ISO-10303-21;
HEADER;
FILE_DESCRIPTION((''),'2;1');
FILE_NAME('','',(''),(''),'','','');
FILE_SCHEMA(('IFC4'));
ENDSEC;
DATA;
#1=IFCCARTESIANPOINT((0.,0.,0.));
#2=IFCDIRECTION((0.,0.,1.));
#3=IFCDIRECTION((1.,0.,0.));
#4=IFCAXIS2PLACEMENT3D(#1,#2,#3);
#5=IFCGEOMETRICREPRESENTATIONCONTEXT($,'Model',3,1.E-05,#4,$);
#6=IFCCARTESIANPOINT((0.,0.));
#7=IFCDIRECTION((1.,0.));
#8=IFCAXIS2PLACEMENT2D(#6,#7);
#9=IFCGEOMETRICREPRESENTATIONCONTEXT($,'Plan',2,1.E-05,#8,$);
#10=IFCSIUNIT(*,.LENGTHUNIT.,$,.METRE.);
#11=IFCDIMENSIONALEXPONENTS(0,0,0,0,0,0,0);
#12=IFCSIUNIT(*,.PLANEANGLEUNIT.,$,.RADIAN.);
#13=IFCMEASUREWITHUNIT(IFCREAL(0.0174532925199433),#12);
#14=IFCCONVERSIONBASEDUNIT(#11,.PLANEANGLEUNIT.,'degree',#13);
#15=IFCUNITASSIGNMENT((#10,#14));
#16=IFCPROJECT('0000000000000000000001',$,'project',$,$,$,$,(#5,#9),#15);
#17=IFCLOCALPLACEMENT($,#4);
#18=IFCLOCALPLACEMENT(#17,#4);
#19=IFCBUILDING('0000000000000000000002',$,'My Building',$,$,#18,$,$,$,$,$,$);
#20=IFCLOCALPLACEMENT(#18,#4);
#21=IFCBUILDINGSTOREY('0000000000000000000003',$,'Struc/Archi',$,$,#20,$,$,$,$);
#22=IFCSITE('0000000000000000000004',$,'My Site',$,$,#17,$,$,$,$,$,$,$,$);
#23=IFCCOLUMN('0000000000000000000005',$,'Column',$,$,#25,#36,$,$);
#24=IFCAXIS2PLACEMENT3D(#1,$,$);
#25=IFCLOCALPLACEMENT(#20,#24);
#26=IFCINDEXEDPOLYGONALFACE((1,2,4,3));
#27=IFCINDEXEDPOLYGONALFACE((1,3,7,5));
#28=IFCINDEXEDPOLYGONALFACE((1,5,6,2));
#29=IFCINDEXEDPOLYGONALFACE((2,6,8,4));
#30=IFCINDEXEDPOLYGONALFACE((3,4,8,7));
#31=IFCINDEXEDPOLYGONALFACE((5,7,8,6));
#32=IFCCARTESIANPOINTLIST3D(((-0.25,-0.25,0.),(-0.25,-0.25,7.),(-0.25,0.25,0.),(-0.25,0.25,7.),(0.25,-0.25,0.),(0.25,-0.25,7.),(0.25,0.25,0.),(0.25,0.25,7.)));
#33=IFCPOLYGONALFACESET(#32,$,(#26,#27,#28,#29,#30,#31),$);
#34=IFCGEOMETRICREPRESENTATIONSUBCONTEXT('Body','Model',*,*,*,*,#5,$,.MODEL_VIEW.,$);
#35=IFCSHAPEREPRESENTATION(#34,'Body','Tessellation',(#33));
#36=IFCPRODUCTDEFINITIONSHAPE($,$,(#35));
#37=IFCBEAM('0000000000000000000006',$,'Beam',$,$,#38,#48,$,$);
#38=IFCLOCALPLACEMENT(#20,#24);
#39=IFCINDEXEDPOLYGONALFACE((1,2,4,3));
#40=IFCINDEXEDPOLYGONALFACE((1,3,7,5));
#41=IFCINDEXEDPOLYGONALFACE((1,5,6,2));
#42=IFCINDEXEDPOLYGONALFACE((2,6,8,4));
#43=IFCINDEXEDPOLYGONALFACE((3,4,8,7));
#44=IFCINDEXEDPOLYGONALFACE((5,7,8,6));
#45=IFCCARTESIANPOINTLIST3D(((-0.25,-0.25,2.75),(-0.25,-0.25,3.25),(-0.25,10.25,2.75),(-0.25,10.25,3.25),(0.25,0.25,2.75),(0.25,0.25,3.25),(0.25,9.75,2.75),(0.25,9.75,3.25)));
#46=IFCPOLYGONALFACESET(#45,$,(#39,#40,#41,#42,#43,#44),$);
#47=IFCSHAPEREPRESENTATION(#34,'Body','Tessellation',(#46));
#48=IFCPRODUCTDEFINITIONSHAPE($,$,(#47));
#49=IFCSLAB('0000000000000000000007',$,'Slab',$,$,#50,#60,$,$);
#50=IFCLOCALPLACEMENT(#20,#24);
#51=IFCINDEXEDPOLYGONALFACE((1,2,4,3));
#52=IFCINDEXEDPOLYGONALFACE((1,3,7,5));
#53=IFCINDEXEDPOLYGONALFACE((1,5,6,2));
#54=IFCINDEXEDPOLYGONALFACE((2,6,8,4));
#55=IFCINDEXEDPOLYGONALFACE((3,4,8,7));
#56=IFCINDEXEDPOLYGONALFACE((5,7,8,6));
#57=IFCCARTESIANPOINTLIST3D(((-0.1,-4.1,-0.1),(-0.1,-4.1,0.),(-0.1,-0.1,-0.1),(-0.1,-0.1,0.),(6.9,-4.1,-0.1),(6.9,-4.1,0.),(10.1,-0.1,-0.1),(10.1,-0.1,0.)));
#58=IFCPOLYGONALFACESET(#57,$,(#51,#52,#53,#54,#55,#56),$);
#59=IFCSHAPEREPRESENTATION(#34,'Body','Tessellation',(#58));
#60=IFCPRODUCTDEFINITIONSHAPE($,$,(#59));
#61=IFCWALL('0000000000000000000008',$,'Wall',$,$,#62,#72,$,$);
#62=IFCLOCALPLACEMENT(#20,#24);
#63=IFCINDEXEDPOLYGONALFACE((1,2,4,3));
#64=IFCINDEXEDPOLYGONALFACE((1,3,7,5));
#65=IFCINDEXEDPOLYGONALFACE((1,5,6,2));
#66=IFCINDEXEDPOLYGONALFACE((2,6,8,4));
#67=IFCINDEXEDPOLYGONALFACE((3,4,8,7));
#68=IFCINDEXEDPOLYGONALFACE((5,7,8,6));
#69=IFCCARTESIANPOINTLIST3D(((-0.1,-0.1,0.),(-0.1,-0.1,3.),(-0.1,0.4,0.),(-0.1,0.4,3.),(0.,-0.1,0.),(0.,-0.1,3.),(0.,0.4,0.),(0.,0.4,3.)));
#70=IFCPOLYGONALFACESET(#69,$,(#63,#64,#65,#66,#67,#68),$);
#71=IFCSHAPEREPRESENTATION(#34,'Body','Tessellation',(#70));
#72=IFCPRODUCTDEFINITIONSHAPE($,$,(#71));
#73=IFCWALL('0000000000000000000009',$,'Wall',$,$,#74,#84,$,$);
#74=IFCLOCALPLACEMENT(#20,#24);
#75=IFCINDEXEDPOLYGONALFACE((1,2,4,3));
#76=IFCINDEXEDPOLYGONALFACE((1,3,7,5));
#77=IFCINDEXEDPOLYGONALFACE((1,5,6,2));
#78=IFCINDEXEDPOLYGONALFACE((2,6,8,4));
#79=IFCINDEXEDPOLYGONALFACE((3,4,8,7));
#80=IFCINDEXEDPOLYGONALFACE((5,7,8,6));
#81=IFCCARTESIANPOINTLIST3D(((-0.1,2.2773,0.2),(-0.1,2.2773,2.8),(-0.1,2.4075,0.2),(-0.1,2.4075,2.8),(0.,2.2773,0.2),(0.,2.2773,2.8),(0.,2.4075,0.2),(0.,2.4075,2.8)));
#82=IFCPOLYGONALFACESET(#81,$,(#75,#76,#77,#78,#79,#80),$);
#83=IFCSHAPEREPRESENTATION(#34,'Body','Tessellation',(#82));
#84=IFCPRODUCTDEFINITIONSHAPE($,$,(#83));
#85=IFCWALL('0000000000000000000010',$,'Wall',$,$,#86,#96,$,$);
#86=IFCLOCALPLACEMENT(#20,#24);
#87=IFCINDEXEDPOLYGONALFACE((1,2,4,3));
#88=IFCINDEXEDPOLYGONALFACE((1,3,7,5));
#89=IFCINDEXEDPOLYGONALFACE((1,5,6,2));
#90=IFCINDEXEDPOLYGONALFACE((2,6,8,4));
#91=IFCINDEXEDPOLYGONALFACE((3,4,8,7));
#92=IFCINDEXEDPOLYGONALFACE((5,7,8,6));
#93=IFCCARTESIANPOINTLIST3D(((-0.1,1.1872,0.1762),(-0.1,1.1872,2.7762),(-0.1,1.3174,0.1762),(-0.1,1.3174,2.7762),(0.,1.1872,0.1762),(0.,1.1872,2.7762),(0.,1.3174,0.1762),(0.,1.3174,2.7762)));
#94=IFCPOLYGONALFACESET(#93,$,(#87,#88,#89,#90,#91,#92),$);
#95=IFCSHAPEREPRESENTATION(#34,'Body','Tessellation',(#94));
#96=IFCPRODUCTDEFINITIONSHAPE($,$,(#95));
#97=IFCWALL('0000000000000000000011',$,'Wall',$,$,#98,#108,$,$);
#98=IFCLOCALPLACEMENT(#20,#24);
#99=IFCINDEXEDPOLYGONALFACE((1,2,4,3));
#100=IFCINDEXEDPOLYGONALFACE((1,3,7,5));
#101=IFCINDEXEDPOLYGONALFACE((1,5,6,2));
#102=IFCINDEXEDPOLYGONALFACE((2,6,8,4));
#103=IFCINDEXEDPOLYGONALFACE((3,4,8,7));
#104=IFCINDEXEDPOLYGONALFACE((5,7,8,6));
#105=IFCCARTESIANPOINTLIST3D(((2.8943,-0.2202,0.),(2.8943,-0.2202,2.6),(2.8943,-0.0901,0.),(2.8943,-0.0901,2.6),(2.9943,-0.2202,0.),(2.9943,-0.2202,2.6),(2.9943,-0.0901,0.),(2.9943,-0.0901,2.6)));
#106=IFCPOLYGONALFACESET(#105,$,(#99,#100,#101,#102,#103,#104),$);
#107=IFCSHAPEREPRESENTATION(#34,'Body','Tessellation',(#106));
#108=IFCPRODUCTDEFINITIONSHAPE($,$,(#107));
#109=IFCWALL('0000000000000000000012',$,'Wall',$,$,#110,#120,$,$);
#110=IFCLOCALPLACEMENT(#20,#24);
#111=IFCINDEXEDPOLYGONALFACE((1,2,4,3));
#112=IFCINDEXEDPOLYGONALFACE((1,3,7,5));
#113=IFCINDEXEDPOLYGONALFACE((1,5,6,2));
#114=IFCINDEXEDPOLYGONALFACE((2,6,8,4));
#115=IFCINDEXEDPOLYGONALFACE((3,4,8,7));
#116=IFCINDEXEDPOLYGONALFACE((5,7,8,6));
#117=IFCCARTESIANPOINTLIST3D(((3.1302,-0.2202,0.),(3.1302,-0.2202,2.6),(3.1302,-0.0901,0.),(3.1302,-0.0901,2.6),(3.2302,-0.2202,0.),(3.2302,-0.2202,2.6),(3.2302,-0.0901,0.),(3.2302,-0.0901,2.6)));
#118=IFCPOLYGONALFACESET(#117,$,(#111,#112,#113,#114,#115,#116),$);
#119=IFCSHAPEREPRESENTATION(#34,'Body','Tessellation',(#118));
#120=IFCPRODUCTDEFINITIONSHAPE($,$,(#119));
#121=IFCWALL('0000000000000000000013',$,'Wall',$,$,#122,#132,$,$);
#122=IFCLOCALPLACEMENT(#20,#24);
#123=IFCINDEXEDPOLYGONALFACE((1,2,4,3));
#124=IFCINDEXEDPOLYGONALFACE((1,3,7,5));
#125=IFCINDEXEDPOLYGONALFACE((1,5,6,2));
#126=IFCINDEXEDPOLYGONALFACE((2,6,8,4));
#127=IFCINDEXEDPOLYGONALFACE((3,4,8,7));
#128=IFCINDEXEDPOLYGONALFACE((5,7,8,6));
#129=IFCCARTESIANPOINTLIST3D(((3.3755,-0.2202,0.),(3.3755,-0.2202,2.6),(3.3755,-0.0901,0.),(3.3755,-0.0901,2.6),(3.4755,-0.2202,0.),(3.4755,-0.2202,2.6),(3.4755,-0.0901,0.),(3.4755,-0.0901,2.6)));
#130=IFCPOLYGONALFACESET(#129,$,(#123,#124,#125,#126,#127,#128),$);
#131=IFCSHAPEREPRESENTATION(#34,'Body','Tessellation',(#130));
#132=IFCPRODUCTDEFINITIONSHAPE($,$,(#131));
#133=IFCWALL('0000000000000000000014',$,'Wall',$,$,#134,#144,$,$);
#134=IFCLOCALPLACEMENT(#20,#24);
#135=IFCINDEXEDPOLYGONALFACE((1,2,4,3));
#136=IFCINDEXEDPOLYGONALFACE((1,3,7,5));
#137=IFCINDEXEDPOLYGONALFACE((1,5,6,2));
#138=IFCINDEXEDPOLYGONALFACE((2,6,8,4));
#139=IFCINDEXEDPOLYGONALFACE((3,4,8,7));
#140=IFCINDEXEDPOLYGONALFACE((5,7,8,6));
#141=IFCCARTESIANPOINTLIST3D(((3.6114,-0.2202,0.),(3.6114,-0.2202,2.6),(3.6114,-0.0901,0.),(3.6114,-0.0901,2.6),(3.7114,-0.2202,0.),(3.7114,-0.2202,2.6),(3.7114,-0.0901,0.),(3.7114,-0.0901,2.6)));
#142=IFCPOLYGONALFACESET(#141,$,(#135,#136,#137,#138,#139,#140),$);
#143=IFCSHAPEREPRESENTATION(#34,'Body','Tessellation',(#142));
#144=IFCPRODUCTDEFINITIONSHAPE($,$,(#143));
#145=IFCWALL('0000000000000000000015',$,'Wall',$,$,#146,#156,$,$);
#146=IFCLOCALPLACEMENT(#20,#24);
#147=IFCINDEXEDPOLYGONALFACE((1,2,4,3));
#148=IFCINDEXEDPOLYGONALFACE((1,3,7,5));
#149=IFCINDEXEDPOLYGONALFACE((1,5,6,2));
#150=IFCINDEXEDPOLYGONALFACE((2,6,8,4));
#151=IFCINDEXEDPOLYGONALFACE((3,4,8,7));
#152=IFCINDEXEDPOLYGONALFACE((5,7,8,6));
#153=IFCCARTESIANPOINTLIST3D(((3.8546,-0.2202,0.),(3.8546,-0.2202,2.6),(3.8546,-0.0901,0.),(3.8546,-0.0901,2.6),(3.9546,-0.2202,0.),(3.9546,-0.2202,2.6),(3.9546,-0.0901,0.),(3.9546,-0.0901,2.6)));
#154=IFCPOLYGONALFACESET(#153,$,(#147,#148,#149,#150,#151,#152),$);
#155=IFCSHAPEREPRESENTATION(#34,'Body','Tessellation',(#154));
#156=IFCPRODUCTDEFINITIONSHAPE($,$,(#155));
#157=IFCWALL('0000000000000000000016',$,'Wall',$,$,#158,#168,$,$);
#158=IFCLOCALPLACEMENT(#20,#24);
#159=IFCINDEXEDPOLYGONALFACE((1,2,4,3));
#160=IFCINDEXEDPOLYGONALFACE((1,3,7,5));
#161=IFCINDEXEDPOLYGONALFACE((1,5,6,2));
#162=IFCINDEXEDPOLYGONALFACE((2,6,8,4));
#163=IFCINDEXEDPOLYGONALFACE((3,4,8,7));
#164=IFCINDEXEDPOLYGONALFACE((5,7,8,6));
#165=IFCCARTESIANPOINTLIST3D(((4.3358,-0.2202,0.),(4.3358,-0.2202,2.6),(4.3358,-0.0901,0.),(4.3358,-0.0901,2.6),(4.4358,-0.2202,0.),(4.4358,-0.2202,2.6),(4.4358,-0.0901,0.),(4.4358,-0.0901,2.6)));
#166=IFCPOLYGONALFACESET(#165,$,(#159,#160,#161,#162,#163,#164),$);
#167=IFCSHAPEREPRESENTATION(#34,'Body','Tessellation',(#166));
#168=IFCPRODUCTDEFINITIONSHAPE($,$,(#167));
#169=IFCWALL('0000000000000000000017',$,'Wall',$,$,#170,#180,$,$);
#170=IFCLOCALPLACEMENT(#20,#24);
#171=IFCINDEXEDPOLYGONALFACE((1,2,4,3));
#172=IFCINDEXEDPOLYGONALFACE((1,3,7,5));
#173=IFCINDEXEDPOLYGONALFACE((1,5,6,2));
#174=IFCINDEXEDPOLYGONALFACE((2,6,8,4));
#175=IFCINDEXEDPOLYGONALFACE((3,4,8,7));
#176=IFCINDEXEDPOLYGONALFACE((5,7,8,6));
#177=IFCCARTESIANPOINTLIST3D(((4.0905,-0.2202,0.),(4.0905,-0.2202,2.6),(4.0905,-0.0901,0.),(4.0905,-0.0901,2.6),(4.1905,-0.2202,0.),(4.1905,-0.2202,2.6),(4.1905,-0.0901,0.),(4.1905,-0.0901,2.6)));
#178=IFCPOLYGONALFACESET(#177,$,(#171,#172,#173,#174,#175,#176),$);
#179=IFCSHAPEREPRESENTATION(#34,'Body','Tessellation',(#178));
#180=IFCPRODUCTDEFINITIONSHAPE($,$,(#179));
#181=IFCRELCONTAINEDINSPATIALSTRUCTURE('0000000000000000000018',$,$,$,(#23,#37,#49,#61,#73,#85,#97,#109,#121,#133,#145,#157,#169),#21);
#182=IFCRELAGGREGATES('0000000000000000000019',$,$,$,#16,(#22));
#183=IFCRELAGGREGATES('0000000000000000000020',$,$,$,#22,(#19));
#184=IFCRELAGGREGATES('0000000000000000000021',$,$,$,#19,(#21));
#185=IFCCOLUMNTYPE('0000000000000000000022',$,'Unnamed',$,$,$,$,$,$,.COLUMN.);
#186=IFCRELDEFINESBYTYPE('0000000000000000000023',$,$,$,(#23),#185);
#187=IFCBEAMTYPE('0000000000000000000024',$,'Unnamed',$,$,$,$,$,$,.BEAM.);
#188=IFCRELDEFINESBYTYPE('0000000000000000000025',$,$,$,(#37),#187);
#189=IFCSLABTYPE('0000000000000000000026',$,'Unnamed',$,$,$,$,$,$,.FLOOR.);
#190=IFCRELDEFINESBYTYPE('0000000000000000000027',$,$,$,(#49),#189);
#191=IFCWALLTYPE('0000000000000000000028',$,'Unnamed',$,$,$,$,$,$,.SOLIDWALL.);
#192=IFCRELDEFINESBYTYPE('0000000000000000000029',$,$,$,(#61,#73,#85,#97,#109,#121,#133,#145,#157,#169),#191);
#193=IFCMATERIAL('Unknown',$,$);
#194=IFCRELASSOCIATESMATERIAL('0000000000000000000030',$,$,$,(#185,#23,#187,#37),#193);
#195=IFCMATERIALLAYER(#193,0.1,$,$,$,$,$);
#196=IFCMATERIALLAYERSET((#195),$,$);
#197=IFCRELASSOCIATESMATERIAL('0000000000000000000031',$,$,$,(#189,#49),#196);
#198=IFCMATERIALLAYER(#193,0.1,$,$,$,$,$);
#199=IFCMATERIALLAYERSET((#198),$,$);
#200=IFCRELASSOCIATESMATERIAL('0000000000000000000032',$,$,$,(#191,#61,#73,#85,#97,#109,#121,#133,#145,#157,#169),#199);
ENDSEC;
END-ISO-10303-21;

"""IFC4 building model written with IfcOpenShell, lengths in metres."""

from ifc_helpers import new_model, entity, si_unit, converted_unit, frame, origin_with_axes, origin_2d_with_axis, place, context, subcontext, project, spatial, line, indexed_curve, rectangle, outline, extrude, clip, halfspace, material, layer, layer_set, layer_usage, material_profile, profile_set, profile_usage, type_object, element, save


model = new_model("IFC4")

# Units and contexts
model_context = context("Model", 3, precision=1e-05, world=origin_with_axes())
plan_context = context("Plan", 2, precision=1e-05, world=origin_2d_with_axis())
body_context = subcontext(model_context, "Body", "Model", "MODEL_VIEW")
ifc_project = project(units=[si_unit("LENGTHUNIT", "METRE"), converted_unit("PLANEANGLEUNIT", "degree", entity("IfcReal", 0.0174532925199433), si_unit("PLANEANGLEUNIT", "RADIAN"), dimensions=[0, 0, 0, 0, 0, 0, 0])], contexts=[model_context, plan_context])

# Site, building, storey
site_placement = place(None, origin_with_axes())
site = spatial("IfcSite", under=ifc_project, at=site_placement, Name="My Site")
building_placement = place(site_placement, origin_with_axes())
building = spatial("IfcBuilding", under=site, at=building_placement, Name="My Building")
storey_placement = place(building_placement, origin_with_axes())
storey = spatial("IfcBuildingStorey", under=building, at=storey_placement, Name="Struc/Archi")

# Column
ifc_material = material(Name="Unknown")
ifc_material_profile_1 = material_profile(ifc_material, rectangle(XDim=0.5, YDim=0.5))
ifc_profile_set_1 = profile_set([ifc_material_profile_1])
ifc_profile_usage_1 = profile_usage(ifc_profile_set_1, cardinal=5)
column_type = type_object("IfcColumnType", Name="Unnamed", PredefinedType="COLUMN", material=ifc_profile_set_1)
column_placement = place(storey_placement, frame((0.0, 0.0, 0.0), z_axis=(0.0, 0.0, 1.0), x_axis=(1.0, 0.0, 0.0)))
element("IfcColumn", 1, at=column_placement, inside=storey, type_object=column_type, material=ifc_profile_usage_1, Name="Column", context=body_context, shape_type="SweptSolid", body=[
    extrude(rectangle(XDim=0.5, YDim=0.5), origin_with_axes(), (0.0, 0.0, 1.0), 7.0),
])

# Beam
ifc_material_profile_2 = material_profile(ifc_material, rectangle(XDim=0.5, YDim=0.5))
ifc_profile_set_2 = profile_set([ifc_material_profile_2])
ifc_profile_usage_2 = profile_usage(ifc_profile_set_2, cardinal=5)
beam_type = type_object("IfcBeamType", Name="Unnamed", PredefinedType="BEAM", material=ifc_profile_set_2)
beam_placement = place(storey_placement, frame((0.0, -0.25, 3.0), z_axis=(0.0, 1.0, 0.0), x_axis=(-1.0, 0.0, 0.0)))
element("IfcBeam", 2, at=beam_placement, inside=storey, type_object=beam_type, material=ifc_profile_usage_2, Name="Beam", context=body_context, shape_type="Clipping", body=[
    clip(clip(extrude(rectangle(XDim=0.5, YDim=0.5), origin_with_axes(), (0.0, 0.0, 1.0), 10.5), halfspace(frame((0.25, -3.0, 10.5), z_axis=(-0.707107, 0.0, 0.707107), x_axis=(0.0, 1.0, 0.0)), False)), halfspace(frame((0.25, -3.0, 0.0), z_axis=(-0.707107, 0.0, -0.707107), x_axis=(0.0, 1.0, 0.0)), False)),
])

# Slab
ifc_layer_1 = layer(ifc_material, 0.1)
ifc_layer_set_1 = layer_set([ifc_layer_1])
ifc_layer_usage_1 = layer_usage(ifc_layer_set_1, "AXIS3", "POSITIVE", -0.1)
slab_type = type_object("IfcSlabType", Name="Unnamed", PredefinedType="FLOOR", material=ifc_layer_set_1)
slab_placement = place(storey_placement, frame((-0.1, -0.1, 0.0), z_axis=(0.0, 0.0, 1.0), x_axis=(1.0, 0.0, 0.0)))
element("IfcSlab", 3, at=slab_placement, inside=storey, type_object=slab_type, material=ifc_layer_usage_1, Name="Slab", context=body_context, shape_type="SweptSolid", body=[
    extrude(outline(indexed_curve([(0.0, 0.0), (0.0, -4.0), (7.0, -4.0), (10.2, 0.0), (0.0, 0.0)])), frame((0.0, 0.0, -0.1), z_axis=(0.0, 0.0, 1.0), x_axis=(1.0, 0.0, 0.0)), (0.0, 0.0, 1.0), 0.1),
])

# Walls
ifc_layer_2 = layer(ifc_material, 0.1)
ifc_layer_set_2 = layer_set([ifc_layer_2])
ifc_layer_usage_2 = layer_usage(ifc_layer_set_2, "AXIS2", "POSITIVE", 0.0)
wall_type = type_object("IfcWallType", Name="Unnamed", PredefinedType="SOLIDWALL", material=ifc_layer_set_2)
wall_1_placement = place(storey_placement, frame((0.0, -0.1, 0.0), z_axis=(0.0, 0.0, 1.0), x_axis=(0.0, 1.0, 0.0)))
element("IfcWall", 4, at=wall_1_placement, inside=storey, type_object=wall_type, material=ifc_layer_usage_2, Name="Wall", context=body_context, shape_type="SweptSolid", body=[
    extrude(outline(indexed_curve([(0.0, 0.0), (0.0, 0.1), (0.5, 0.1), (0.5, 0.0)], segments=[line(1, 2, 3, 4, 1)])), origin_with_axes(), (0.0, 0.0, 1.0), 3.0),
])
ifc_layer_usage_3 = layer_usage(ifc_layer_set_2, "AXIS2", "POSITIVE", 0.0)
wall_2_placement = place(storey_placement, frame((-0.1, 2.4075, 0.2), z_axis=(0.0, 0.0, 1.0), x_axis=(0.0, -1.0, 0.0)))
element("IfcWall", 5, at=wall_2_placement, inside=storey, type_object=wall_type, material=ifc_layer_usage_3, Name="Wall", context=body_context, shape_type="SweptSolid", body=[
    extrude(outline(indexed_curve([(0.0, 0.0), (0.0, 0.1), (0.1301, 0.1), (0.1301, 0.0)], segments=[line(1, 2, 3, 4, 1)])), origin_with_axes(), (0.0, 0.0, 1.0), 2.6),
])
ifc_layer_usage_4 = layer_usage(ifc_layer_set_2, "AXIS2", "POSITIVE", 0.0)
wall_3_placement = place(storey_placement, frame((-0.1, 1.3174, 0.1762), z_axis=(0.0, 0.0, 1.0), x_axis=(0.0, -1.0, 0.0)))
element("IfcWall", 6, at=wall_3_placement, inside=storey, type_object=wall_type, material=ifc_layer_usage_4, Name="Wall", context=body_context, shape_type="SweptSolid", body=[
    extrude(outline(indexed_curve([(0.0, 0.0), (0.0, 0.1), (0.1301, 0.1), (0.1301, 0.0)], segments=[line(1, 2, 3, 4, 1)])), origin_with_axes(), (0.0, 0.0, 1.0), 2.6),
])
ifc_layer_usage_5 = layer_usage(ifc_layer_set_2, "AXIS2", "POSITIVE", 0.0)
wall_4_placement = place(storey_placement, frame((2.8943, -0.0901, 0.0), z_axis=(0.0, 0.0, 1.0), x_axis=(0.0, -1.0, 0.0)))
element("IfcWall", 7, at=wall_4_placement, inside=storey, type_object=wall_type, material=ifc_layer_usage_5, Name="Wall", context=body_context, shape_type="SweptSolid", body=[
    extrude(outline(indexed_curve([(0.0, 0.0), (0.0, 0.1), (0.1301, 0.1), (0.1301, 0.0)], segments=[line(1, 2, 3, 4, 1)])), origin_with_axes(), (0.0, 0.0, 1.0), 2.6),
])
ifc_layer_usage_6 = layer_usage(ifc_layer_set_2, "AXIS2", "POSITIVE", 0.0)
wall_5_placement = place(storey_placement, frame((3.1302, -0.0901, 0.0), z_axis=(0.0, 0.0, 1.0), x_axis=(0.0, -1.0, 0.0)))
element("IfcWall", 8, at=wall_5_placement, inside=storey, type_object=wall_type, material=ifc_layer_usage_6, Name="Wall", context=body_context, shape_type="SweptSolid", body=[
    extrude(outline(indexed_curve([(0.0, 0.0), (0.0, 0.1), (0.1301, 0.1), (0.1301, 0.0)], segments=[line(1, 2, 3, 4, 1)])), origin_with_axes(), (0.0, 0.0, 1.0), 2.6),
])
ifc_layer_usage_7 = layer_usage(ifc_layer_set_2, "AXIS2", "POSITIVE", 0.0)
wall_6_placement = place(storey_placement, frame((3.3755, -0.0901, 0.0), z_axis=(0.0, 0.0, 1.0), x_axis=(0.0, -1.0, 0.0)))
element("IfcWall", 9, at=wall_6_placement, inside=storey, type_object=wall_type, material=ifc_layer_usage_7, Name="Wall", context=body_context, shape_type="SweptSolid", body=[
    extrude(outline(indexed_curve([(0.0, 0.0), (0.0, 0.1), (0.1301, 0.1), (0.1301, 0.0)], segments=[line(1, 2, 3, 4, 1)])), origin_with_axes(), (0.0, 0.0, 1.0), 2.6),
])
ifc_layer_usage_8 = layer_usage(ifc_layer_set_2, "AXIS2", "POSITIVE", 0.0)
wall_7_placement = place(storey_placement, frame((3.6114, -0.0901, 0.0), z_axis=(0.0, 0.0, 1.0), x_axis=(0.0, -1.0, 0.0)))
element("IfcWall", 10, at=wall_7_placement, inside=storey, type_object=wall_type, material=ifc_layer_usage_8, Name="Wall", context=body_context, shape_type="SweptSolid", body=[
    extrude(outline(indexed_curve([(0.0, 0.0), (0.0, 0.1), (0.1301, 0.1), (0.1301, 0.0)], segments=[line(1, 2, 3, 4, 1)])), origin_with_axes(), (0.0, 0.0, 1.0), 2.6),
])
ifc_layer_usage_9 = layer_usage(ifc_layer_set_2, "AXIS2", "POSITIVE", 0.0)
wall_8_placement = place(storey_placement, frame((3.8546, -0.0901, 0.0), z_axis=(0.0, 0.0, 1.0), x_axis=(0.0, -1.0, 0.0)))
element("IfcWall", 11, at=wall_8_placement, inside=storey, type_object=wall_type, material=ifc_layer_usage_9, Name="Wall", context=body_context, shape_type="SweptSolid", body=[
    extrude(outline(indexed_curve([(0.0, 0.0), (0.0, 0.1), (0.1301, 0.1), (0.1301, 0.0)], segments=[line(1, 2, 3, 4, 1)])), origin_with_axes(), (0.0, 0.0, 1.0), 2.6),
])
ifc_layer_usage_10 = layer_usage(ifc_layer_set_2, "AXIS2", "POSITIVE", 0.0)
wall_9_placement = place(storey_placement, frame((4.3358, -0.0901, 0.0), z_axis=(0.0, 0.0, 1.0), x_axis=(0.0, -1.0, 0.0)))
element("IfcWall", 12, at=wall_9_placement, inside=storey, type_object=wall_type, material=ifc_layer_usage_10, Name="Wall", context=body_context, shape_type="SweptSolid", body=[
    extrude(outline(indexed_curve([(0.0, 0.0), (0.0, 0.1), (0.1301, 0.1), (0.1301, 0.0)], segments=[line(1, 2, 3, 4, 1)])), origin_with_axes(), (0.0, 0.0, 1.0), 2.6),
])
ifc_layer_usage_11 = layer_usage(ifc_layer_set_2, "AXIS2", "POSITIVE", 0.0)
wall_10_placement = place(storey_placement, frame((4.0905, -0.0901, 0.0), z_axis=(0.0, 0.0, 1.0), x_axis=(0.0, -1.0, 0.0)))
element("IfcWall", 13, at=wall_10_placement, inside=storey, type_object=wall_type, material=ifc_layer_usage_11, Name="Wall", context=body_context, shape_type="SweptSolid", body=[
    extrude(outline(indexed_curve([(0.0, 0.0), (0.0, 0.1), (0.1301, 0.1), (0.1301, 0.0)], segments=[line(1, 2, 3, 4, 1)])), origin_with_axes(), (0.0, 0.0, 1.0), 2.6),
])

save(model, "model.ifc")
